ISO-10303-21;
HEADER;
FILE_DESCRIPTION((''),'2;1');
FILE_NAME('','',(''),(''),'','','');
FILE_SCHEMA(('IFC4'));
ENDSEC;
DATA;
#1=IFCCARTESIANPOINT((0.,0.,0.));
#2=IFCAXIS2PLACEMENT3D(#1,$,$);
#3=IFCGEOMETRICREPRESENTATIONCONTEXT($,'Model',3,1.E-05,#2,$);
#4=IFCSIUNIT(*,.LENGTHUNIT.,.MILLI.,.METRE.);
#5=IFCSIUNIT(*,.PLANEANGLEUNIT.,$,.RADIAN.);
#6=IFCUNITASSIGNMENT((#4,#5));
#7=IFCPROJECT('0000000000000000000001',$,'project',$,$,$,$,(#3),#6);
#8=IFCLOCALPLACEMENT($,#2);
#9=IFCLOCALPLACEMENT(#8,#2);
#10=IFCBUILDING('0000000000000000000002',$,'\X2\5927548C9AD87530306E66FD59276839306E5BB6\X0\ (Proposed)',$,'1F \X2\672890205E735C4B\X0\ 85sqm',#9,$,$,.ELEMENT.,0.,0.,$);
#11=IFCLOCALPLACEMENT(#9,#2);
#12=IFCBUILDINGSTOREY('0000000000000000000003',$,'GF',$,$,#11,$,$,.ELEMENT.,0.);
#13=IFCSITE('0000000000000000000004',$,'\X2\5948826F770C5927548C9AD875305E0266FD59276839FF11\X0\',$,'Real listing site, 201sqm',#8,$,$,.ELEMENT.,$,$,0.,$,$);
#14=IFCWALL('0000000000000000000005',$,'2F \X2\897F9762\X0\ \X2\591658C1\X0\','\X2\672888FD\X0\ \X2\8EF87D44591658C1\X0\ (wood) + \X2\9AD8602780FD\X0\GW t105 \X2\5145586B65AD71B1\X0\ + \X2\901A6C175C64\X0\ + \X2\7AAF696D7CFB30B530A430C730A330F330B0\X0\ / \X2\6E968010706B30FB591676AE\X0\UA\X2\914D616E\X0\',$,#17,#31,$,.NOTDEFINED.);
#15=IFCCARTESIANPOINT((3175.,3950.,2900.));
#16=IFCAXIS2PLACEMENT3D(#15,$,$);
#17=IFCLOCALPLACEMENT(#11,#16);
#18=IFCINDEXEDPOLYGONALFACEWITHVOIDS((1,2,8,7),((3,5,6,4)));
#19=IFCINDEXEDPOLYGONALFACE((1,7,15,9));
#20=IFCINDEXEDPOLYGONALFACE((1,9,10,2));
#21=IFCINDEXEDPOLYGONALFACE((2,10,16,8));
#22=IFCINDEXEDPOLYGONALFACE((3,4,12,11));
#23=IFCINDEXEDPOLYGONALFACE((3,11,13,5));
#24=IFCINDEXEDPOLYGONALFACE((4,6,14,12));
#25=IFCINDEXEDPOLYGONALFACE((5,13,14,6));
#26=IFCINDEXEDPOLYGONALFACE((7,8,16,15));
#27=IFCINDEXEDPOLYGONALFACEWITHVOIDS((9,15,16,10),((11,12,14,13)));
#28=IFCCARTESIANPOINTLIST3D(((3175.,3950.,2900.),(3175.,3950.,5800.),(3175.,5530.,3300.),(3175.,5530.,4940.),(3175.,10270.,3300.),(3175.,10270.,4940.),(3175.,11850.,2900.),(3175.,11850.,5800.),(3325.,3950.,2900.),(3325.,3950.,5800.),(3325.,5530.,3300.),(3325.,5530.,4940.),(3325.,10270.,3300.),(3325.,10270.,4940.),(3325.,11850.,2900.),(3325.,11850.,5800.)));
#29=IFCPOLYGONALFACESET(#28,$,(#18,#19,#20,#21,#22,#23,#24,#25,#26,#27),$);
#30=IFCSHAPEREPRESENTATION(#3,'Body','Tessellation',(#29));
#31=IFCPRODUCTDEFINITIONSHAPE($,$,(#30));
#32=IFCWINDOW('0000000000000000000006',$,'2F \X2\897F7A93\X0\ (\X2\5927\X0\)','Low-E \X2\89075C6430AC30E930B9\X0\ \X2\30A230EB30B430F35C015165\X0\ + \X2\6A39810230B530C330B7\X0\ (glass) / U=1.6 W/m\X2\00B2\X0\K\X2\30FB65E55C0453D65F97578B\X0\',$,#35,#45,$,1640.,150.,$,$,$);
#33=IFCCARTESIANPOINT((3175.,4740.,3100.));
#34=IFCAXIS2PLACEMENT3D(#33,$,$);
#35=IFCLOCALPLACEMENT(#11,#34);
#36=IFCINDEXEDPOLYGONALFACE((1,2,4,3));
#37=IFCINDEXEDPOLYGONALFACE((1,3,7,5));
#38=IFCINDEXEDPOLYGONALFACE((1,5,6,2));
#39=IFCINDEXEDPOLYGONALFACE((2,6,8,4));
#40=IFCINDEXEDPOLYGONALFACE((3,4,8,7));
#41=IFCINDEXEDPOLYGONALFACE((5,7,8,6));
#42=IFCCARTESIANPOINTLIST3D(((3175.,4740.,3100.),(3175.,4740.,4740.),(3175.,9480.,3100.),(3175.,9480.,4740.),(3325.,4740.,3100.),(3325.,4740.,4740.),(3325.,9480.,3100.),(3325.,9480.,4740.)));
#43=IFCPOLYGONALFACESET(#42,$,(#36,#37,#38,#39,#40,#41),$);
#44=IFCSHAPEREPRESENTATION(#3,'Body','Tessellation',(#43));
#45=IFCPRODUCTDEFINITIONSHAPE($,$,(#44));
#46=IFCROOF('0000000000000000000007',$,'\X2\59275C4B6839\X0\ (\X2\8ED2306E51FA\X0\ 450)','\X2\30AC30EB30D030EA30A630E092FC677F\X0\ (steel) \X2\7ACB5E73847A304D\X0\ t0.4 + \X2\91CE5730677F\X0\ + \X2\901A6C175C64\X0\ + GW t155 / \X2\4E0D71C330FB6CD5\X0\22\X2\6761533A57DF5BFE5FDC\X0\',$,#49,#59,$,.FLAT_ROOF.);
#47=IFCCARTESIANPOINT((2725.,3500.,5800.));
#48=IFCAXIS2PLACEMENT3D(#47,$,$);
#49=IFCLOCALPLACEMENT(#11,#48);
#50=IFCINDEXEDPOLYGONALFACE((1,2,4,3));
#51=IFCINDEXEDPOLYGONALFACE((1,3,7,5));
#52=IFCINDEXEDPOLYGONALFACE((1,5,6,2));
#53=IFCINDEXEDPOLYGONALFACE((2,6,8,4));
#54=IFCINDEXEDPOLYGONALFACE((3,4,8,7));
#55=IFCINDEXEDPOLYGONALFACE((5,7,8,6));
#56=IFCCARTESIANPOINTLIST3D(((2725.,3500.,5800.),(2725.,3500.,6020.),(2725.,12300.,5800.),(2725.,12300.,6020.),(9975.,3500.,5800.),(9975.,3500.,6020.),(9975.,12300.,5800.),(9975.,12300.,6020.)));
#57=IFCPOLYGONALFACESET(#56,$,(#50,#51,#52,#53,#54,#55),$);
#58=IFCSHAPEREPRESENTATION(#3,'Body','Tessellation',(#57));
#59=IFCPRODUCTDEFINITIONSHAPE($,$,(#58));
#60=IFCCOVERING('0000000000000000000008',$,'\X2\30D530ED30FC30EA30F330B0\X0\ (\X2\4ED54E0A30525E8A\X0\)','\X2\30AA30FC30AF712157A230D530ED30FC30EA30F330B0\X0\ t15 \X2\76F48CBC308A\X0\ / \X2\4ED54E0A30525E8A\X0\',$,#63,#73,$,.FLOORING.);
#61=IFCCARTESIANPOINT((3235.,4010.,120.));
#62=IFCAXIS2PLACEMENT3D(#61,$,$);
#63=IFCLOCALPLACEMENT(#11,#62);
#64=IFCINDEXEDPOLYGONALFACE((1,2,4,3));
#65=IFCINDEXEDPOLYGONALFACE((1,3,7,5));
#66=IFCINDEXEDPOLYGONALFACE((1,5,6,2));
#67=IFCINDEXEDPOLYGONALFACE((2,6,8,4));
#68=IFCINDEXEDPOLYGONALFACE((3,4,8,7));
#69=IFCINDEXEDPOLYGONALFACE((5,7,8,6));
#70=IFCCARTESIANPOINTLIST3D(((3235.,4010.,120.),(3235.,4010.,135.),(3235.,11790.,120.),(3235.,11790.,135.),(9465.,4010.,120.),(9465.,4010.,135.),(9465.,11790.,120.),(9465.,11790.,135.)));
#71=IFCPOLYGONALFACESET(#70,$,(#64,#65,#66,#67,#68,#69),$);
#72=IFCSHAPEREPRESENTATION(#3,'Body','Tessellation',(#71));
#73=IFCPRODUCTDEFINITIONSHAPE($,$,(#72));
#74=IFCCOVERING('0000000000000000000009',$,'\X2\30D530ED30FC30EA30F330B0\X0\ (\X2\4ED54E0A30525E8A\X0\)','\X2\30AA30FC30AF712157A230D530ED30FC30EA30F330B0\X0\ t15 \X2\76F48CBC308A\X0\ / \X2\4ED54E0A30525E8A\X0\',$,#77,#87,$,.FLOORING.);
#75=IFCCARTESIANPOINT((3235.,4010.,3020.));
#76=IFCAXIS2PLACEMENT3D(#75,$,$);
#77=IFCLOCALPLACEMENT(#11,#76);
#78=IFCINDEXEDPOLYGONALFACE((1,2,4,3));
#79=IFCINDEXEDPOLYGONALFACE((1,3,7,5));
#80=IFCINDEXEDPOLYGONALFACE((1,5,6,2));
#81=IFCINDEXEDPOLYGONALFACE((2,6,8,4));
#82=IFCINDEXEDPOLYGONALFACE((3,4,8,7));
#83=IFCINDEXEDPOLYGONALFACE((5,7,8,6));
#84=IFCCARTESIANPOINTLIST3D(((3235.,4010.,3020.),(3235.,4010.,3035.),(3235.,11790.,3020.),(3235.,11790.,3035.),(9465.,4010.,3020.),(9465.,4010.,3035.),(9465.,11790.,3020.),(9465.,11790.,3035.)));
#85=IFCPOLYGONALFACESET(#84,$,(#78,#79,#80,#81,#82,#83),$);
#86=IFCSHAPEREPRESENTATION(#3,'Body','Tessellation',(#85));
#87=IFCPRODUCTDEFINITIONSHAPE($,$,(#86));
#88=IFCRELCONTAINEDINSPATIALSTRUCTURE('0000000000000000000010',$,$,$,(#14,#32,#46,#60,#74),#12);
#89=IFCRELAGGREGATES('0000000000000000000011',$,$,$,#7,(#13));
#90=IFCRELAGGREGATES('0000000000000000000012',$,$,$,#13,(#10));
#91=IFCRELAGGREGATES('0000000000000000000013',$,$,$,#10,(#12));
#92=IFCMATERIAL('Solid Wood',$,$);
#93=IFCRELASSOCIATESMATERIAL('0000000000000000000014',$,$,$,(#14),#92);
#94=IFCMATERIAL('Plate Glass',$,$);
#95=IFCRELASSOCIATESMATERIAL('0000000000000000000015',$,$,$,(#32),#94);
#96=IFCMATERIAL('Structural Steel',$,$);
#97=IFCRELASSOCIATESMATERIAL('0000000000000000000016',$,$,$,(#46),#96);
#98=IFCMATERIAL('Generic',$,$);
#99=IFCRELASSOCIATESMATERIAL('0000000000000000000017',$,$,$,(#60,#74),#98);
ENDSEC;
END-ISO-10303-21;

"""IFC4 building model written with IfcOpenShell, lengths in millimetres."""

from ifc_helpers import new_model, si_unit, frame, frame_2d, origin, place, context, project, spatial, rectangle, extrude, material, element, fill, save


model = new_model("IFC4")

# Units and contexts
model_context = context("Model", 3, precision=1e-05, world=origin())
ifc_project = project(units=[si_unit("LENGTHUNIT", "METRE", prefix="MILLI"), si_unit("PLANEANGLEUNIT", "RADIAN")], contexts=[model_context])

# Site, building, storey
site_placement = place(None, origin())
site = spatial("IfcSite", under=ifc_project, at=site_placement, Name="奈良県大和高田市曽大根１", ObjectType="Real listing site, 201sqm", CompositionType="ELEMENT", RefElevation=0.0)
building_placement = place(site_placement, origin())
building = spatial("IfcBuilding", under=site, at=building_placement, Name="大和高田の曽大根の家 (Proposed)", ObjectType="1F 木造平屋 85sqm", CompositionType="ELEMENT", ElevationOfRefHeight=0.0, ElevationOfTerrain=0.0)
storey_placement = place(building_placement, origin())
storey = spatial("IfcBuildingStorey", under=building, at=storey_placement, Name="GF", CompositionType="ELEMENT", Elevation=0.0)

# Shared definitions
ifc_material_1 = material(Name="Solid Wood")
ifc_material_2 = material(Name="Generic")

# Shared definitions
ifc_material_3 = material(Name="Plate Glass")

# Wall, opening, window
wall_1_placement = place(storey_placement, frame((3175.0, 3950.0, 2900.0)))
wall_1 = element("IfcWall", 1, at=wall_1_placement, inside=storey, material=ifc_material_1, Name="2F 西面 外壁", Description="木製 軸組外壁 (wood) + 高性能GW t105 充填断熱 + 通気層 + 窯業系サイディング / 準耐火・外皮UA配慮", PredefinedType="NOTDEFINED", context=model_context, shape_type="SweptSolid", body=[
    extrude(rectangle(XDim=150.0, YDim=7900.0, at=frame_2d((75.0, 3950.0))), frame((3175.0, 3950.0, 2900.0)), (0.0, 0.0, 1.0), 2900.0),
])
opening_1_placement = place(storey_placement, frame((3175.0, 4740.0, 3100.0)))
opening_1 = element("IfcOpeningElement", 2, at=opening_1_placement, cuts=wall_1, PredefinedType="NOTDEFINED", context=model_context, shape_type="SweptSolid", body=[
    extrude(rectangle(XDim=150.0, YDim=4740.0, at=frame_2d((75.0, 2370.0))), frame((3175.0, 4740.0, 3100.0)), (0.0, 0.0, 1.0), 1640.0),
])
window_1_placement = place(storey_placement, frame((3175.0, 4740.0, 3100.0)))
window_1 = element("IfcWindow", 3, at=window_1_placement, inside=storey, material=ifc_material_3, Name="2F 西窓 (大)", Description="Low-E 複層ガラス アルゴン封入 + 樹脂サッシ (glass) / U=1.6 W/m²K・日射取得型", OverallHeight=1640.0, OverallWidth=150.0, context=model_context, shape_type="SweptSolid", body=[
    extrude(rectangle(XDim=150.0, YDim=4740.0, at=frame_2d((75.0, 2370.0))), frame((3175.0, 4740.0, 3100.0)), (0.0, 0.0, 1.0), 1640.0),
])
fill(opening_1, window_1)

# Roof
ifc_material_4 = material(Name="Structural Steel")
roof_placement = place(storey_placement, frame((2725.0, 3500.0, 5800.0)))
element("IfcRoof", 4, at=roof_placement, inside=storey, material=ifc_material_4, Name="大屋根 (軒の出 450)", Description="ガルバリウム鋼板 (steel) 立平葺き t0.4 + 野地板 + 通気層 + GW t155 / 不燃・法22条区域対応", PredefinedType="FLAT_ROOF", context=model_context, shape_type="SweptSolid", body=[
    extrude(rectangle(XDim=7250.0, YDim=8800.0, at=frame_2d((3625.0, 4400.0))), frame((2725.0, 3500.0, 5800.0)), (0.0, 0.0, 1.0), 220.0),
])

# Coverings
covering_1_placement = place(storey_placement, frame((3235.0, 4010.0, 120.0)))
element("IfcCovering", 5, at=covering_1_placement, inside=storey, material=ifc_material_2, Name="フローリング (仕上げ床)", Description="オーク無垢フローリング t15 直貼り / 仕上げ床", PredefinedType="FLOORING", context=model_context, shape_type="SweptSolid", body=[
    extrude(rectangle(XDim=6230.0, YDim=7780.0, at=frame_2d((3115.0, 3890.0))), frame((3235.0, 4010.0, 120.0)), (0.0, 0.0, 1.0), 15.0),
])
covering_2_placement = place(storey_placement, frame((3235.0, 4010.0, 3020.0)))
element("IfcCovering", 6, at=covering_2_placement, inside=storey, material=ifc_material_2, Name="フローリング (仕上げ床)", Description="オーク無垢フローリング t15 直貼り / 仕上げ床", PredefinedType="FLOORING", context=model_context, shape_type="SweptSolid", body=[
    extrude(rectangle(XDim=6230.0, YDim=7780.0, at=frame_2d((3115.0, 3890.0))), frame((3235.0, 4010.0, 3020.0)), (0.0, 0.0, 1.0), 15.0),
])

save(model, "model.ifc")
